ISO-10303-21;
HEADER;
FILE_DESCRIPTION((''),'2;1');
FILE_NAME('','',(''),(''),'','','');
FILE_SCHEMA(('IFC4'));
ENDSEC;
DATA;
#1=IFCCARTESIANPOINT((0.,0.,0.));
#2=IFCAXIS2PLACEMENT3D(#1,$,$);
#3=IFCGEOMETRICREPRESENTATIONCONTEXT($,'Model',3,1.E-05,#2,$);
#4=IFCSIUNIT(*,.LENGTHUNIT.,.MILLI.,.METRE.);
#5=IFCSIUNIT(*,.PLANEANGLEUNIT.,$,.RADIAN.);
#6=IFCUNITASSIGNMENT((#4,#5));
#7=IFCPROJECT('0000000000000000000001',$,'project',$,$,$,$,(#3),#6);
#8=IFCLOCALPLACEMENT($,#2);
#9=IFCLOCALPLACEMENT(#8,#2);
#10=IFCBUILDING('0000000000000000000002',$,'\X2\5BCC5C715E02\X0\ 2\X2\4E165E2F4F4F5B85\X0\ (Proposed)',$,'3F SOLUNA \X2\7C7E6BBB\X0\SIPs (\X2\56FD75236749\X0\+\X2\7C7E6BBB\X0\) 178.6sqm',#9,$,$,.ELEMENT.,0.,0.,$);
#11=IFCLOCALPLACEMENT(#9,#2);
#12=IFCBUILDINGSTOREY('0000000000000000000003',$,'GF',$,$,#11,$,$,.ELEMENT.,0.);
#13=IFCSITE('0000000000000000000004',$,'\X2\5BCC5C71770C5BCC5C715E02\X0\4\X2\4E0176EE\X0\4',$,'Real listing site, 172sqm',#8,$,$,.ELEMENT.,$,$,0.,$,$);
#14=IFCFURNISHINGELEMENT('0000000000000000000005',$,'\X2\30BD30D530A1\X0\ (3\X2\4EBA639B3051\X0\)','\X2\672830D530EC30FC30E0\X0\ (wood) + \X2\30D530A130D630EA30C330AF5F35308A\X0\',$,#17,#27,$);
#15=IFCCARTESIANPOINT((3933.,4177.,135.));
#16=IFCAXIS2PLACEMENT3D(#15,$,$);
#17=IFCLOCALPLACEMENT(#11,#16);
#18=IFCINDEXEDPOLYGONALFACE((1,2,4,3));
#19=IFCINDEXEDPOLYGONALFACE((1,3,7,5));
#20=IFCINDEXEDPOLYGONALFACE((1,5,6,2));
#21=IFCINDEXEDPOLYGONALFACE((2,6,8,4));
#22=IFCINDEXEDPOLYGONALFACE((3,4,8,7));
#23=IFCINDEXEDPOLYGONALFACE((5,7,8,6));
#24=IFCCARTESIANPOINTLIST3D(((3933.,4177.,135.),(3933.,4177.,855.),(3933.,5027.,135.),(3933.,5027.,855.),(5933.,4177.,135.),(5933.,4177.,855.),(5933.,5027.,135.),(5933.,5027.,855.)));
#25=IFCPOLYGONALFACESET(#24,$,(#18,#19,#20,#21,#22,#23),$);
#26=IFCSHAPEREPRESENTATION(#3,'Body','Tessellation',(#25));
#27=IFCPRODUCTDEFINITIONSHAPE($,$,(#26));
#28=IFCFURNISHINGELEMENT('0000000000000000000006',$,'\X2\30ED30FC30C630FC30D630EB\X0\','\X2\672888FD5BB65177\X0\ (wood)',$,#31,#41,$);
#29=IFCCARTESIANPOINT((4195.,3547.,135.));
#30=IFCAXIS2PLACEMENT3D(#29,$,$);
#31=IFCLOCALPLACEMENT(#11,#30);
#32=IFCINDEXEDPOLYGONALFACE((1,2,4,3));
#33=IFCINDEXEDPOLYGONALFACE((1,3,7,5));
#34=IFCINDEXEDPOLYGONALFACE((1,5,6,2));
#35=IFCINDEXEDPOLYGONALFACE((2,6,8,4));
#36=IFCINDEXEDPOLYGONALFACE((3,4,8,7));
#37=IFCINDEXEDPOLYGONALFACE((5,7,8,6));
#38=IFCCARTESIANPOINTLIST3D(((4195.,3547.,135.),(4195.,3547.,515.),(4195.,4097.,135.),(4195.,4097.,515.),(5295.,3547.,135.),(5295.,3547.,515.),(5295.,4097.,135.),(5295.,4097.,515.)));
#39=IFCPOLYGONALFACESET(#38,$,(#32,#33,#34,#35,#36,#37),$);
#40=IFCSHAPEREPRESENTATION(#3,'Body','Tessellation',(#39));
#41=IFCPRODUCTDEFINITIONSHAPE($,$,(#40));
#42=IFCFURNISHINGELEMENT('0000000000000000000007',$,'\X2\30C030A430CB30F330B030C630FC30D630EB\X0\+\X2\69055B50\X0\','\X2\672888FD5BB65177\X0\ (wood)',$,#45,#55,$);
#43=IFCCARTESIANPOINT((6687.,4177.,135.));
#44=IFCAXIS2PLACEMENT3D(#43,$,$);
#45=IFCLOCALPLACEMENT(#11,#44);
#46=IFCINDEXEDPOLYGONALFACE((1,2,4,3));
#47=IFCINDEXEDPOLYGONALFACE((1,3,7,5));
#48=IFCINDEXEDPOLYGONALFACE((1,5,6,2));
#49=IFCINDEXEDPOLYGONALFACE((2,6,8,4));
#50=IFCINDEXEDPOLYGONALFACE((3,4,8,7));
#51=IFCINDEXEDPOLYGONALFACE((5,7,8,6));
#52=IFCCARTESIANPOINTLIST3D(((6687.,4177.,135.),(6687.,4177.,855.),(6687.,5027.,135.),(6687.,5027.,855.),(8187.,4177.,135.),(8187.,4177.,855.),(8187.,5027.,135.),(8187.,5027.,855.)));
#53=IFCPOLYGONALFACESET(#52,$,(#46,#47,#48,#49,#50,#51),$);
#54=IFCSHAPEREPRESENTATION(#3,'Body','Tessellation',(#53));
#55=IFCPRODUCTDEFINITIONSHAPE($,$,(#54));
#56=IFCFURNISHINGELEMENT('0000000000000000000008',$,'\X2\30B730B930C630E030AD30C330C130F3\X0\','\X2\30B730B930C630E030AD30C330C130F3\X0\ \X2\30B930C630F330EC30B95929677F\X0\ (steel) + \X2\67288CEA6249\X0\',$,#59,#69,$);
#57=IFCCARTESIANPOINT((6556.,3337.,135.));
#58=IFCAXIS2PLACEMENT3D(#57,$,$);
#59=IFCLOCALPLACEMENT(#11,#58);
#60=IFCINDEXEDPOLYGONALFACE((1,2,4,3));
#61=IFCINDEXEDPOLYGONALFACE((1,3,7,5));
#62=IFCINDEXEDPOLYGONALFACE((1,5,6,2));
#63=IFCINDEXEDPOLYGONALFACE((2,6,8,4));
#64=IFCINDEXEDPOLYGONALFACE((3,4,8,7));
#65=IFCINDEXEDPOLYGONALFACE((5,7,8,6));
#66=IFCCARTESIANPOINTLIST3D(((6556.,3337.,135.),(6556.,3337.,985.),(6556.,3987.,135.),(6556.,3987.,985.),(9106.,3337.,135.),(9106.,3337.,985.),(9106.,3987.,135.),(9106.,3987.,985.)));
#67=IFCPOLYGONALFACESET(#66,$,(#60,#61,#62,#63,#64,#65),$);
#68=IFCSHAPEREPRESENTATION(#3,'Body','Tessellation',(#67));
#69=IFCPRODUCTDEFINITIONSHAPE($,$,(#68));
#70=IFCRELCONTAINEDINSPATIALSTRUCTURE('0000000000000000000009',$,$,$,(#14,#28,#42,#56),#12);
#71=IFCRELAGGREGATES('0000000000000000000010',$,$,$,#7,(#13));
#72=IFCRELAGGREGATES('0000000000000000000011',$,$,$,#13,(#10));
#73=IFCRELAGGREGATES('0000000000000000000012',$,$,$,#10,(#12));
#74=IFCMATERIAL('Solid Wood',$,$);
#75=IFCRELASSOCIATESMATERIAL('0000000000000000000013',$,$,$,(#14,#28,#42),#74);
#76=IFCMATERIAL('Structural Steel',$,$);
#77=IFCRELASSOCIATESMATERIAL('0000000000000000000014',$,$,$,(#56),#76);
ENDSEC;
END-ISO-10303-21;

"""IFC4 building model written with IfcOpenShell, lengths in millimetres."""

from ifc_helpers import new_model, si_unit, frame, frame_2d, origin, place, context, project, spatial, rectangle, extrude, material, element, save


model = new_model("IFC4")

# Units and contexts
model_context = context("Model", 3, precision=1e-05, world=origin())
ifc_project = project(units=[si_unit("LENGTHUNIT", "METRE", prefix="MILLI"), si_unit("PLANEANGLEUNIT", "RADIAN")], contexts=[model_context])

# Site, building, storey
site_placement = place(None, origin())
site = spatial("IfcSite", under=ifc_project, at=site_placement, Name="富山県富山市4丁目4", ObjectType="Real listing site, 172sqm", CompositionType="ELEMENT", RefElevation=0.0)
building_placement = place(site_placement, origin())
building = spatial("IfcBuilding", under=site, at=building_placement, Name="富山市 2世帯住宅 (Proposed)", ObjectType="3F SOLUNA 籾殻SIPs (国産杉+籾殻) 178.6sqm", CompositionType="ELEMENT", ElevationOfRefHeight=0.0, ElevationOfTerrain=0.0)
storey_placement = place(building_placement, origin())
storey = spatial("IfcBuildingStorey", under=building, at=storey_placement, Name="GF", CompositionType="ELEMENT", Elevation=0.0)

# Shared definitions
ifc_material_1 = material(Name="Solid Wood")

# Furnishing elements
furnishing_1_placement = place(storey_placement, frame((3933.0, 4177.0, 135.0)))
element("IfcFurnishingElement", 1, at=furnishing_1_placement, inside=storey, material=ifc_material_1, Name="ソファ (3人掛け)", Description="木フレーム (wood) + ファブリック張り", context=model_context, shape_type="SweptSolid", body=[
    extrude(rectangle(XDim=2000.0, YDim=850.0, at=frame_2d((1000.0, 425.0))), frame((3933.0, 4177.0, 135.0)), (0.0, 0.0, 1.0), 720.0),
])
furnishing_2_placement = place(storey_placement, frame((4195.0, 3547.0, 135.0)))
element("IfcFurnishingElement", 2, at=furnishing_2_placement, inside=storey, material=ifc_material_1, Name="ローテーブル", Description="木製家具 (wood)", context=model_context, shape_type="SweptSolid", body=[
    extrude(rectangle(XDim=1100.0, YDim=550.0, at=frame_2d((550.0, 275.0))), frame((4195.0, 3547.0, 135.0)), (0.0, 0.0, 1.0), 380.0),
])
furnishing_3_placement = place(storey_placement, frame((6687.0, 4177.0, 135.0)))
element("IfcFurnishingElement", 3, at=furnishing_3_placement, inside=storey, material=ifc_material_1, Name="ダイニングテーブル+椅子", Description="木製家具 (wood)", context=model_context, shape_type="SweptSolid", body=[
    extrude(rectangle(XDim=1500.0, YDim=850.0, at=frame_2d((750.0, 425.0))), frame((6687.0, 4177.0, 135.0)), (0.0, 0.0, 1.0), 720.0),
])
ifc_material_2 = material(Name="Structural Steel")
furnishing_4_placement = place(storey_placement, frame((6556.0, 3337.0, 135.0)))
element("IfcFurnishingElement", 4, at=furnishing_4_placement, inside=storey, material=ifc_material_2, Name="システムキッチン", Description="システムキッチン ステンレス天板 (steel) + 木質扉", context=model_context, shape_type="SweptSolid", body=[
    extrude(rectangle(XDim=2550.0, YDim=650.0, at=frame_2d((1275.0, 325.0))), frame((6556.0, 3337.0, 135.0)), (0.0, 0.0, 1.0), 850.0),
])

save(model, "model.ifc")
